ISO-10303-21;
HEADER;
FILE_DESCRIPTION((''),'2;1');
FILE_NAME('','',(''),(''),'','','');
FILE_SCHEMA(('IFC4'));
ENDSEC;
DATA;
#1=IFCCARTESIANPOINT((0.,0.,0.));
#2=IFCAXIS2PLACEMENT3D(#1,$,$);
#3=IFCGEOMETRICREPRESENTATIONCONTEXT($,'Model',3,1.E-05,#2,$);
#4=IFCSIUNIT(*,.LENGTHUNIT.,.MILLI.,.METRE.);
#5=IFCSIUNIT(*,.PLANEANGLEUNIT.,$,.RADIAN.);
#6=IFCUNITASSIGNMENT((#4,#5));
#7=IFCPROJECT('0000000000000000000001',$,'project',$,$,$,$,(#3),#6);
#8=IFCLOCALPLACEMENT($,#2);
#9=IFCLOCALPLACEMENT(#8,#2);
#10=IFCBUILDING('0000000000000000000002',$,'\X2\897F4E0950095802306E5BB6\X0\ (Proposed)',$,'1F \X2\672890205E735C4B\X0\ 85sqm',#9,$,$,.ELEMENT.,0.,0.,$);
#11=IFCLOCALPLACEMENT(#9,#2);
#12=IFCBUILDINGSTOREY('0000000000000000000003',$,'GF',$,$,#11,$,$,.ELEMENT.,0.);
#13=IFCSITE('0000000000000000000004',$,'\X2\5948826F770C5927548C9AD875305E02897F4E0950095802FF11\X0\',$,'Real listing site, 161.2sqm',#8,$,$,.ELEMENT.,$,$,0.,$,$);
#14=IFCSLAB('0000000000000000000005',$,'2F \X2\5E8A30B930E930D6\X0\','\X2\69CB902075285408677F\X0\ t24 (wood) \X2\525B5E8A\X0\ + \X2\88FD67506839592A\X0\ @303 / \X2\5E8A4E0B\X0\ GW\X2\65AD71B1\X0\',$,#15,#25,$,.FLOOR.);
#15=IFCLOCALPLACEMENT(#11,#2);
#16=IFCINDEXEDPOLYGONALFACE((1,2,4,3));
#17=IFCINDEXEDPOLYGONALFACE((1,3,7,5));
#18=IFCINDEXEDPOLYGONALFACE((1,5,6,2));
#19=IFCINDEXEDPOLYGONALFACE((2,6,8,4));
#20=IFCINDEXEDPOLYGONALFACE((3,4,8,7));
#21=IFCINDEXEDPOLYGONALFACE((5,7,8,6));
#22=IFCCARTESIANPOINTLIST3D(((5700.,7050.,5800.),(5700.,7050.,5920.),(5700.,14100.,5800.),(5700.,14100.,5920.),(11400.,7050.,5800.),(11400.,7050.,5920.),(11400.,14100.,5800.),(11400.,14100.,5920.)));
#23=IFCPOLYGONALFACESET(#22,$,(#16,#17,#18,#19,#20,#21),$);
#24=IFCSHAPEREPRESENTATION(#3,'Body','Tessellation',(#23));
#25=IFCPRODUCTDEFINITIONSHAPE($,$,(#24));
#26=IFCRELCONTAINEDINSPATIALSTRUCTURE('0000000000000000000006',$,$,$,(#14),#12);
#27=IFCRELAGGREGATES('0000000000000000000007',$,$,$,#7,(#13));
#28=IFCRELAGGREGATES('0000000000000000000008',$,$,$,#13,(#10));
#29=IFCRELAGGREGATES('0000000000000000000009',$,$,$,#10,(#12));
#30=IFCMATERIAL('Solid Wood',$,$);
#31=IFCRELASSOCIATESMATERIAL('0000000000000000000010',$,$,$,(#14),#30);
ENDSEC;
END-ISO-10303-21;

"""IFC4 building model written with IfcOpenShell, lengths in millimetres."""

from ifc_helpers import new_model, si_unit, frame, frame_2d, origin, place, context, project, spatial, rectangle, extrude, material, element, save


model = new_model("IFC4")

# Units and contexts
model_context = context("Model", 3, precision=1e-05, world=origin())
ifc_project = project(units=[si_unit("LENGTHUNIT", "METRE", prefix="MILLI"), si_unit("PLANEANGLEUNIT", "RADIAN")], contexts=[model_context])

# Site, building, storey
site_placement = place(None, origin())
site = spatial("IfcSite", under=ifc_project, at=site_placement, Name="奈良県大和高田市西三倉堂１", ObjectType="Real listing site, 161.2sqm", CompositionType="ELEMENT", RefElevation=0.0)
building_placement = place(site_placement, origin())
building = spatial("IfcBuilding", under=site, at=building_placement, Name="西三倉堂の家 (Proposed)", ObjectType="1F 木造平屋 85sqm", CompositionType="ELEMENT", ElevationOfRefHeight=0.0, ElevationOfTerrain=0.0)
storey_placement = place(building_placement, origin())
storey = spatial("IfcBuildingStorey", under=building, at=storey_placement, Name="GF", CompositionType="ELEMENT", Elevation=0.0)

# Slab
ifc_material_1 = material(Name="Solid Wood")
slab_placement = place(storey_placement, frame((2850.0, 3525.0, 2900.0)))
element("IfcSlab", 1, at=slab_placement, inside=storey, material=ifc_material_1, Name="2F 床スラブ", Description="構造用合板 t24 (wood) 剛床 + 製材根太 @303 / 床下 GW断熱", PredefinedType="FLOOR", context=model_context, shape_type="SweptSolid", body=[
    extrude(rectangle(XDim=5700.0, YDim=7050.0, at=frame_2d((2850.0, 3525.0))), frame((2850.0, 3525.0, 2900.0)), (0.0, 0.0, 1.0), 120.0),
])

save(model, "model.ifc")
